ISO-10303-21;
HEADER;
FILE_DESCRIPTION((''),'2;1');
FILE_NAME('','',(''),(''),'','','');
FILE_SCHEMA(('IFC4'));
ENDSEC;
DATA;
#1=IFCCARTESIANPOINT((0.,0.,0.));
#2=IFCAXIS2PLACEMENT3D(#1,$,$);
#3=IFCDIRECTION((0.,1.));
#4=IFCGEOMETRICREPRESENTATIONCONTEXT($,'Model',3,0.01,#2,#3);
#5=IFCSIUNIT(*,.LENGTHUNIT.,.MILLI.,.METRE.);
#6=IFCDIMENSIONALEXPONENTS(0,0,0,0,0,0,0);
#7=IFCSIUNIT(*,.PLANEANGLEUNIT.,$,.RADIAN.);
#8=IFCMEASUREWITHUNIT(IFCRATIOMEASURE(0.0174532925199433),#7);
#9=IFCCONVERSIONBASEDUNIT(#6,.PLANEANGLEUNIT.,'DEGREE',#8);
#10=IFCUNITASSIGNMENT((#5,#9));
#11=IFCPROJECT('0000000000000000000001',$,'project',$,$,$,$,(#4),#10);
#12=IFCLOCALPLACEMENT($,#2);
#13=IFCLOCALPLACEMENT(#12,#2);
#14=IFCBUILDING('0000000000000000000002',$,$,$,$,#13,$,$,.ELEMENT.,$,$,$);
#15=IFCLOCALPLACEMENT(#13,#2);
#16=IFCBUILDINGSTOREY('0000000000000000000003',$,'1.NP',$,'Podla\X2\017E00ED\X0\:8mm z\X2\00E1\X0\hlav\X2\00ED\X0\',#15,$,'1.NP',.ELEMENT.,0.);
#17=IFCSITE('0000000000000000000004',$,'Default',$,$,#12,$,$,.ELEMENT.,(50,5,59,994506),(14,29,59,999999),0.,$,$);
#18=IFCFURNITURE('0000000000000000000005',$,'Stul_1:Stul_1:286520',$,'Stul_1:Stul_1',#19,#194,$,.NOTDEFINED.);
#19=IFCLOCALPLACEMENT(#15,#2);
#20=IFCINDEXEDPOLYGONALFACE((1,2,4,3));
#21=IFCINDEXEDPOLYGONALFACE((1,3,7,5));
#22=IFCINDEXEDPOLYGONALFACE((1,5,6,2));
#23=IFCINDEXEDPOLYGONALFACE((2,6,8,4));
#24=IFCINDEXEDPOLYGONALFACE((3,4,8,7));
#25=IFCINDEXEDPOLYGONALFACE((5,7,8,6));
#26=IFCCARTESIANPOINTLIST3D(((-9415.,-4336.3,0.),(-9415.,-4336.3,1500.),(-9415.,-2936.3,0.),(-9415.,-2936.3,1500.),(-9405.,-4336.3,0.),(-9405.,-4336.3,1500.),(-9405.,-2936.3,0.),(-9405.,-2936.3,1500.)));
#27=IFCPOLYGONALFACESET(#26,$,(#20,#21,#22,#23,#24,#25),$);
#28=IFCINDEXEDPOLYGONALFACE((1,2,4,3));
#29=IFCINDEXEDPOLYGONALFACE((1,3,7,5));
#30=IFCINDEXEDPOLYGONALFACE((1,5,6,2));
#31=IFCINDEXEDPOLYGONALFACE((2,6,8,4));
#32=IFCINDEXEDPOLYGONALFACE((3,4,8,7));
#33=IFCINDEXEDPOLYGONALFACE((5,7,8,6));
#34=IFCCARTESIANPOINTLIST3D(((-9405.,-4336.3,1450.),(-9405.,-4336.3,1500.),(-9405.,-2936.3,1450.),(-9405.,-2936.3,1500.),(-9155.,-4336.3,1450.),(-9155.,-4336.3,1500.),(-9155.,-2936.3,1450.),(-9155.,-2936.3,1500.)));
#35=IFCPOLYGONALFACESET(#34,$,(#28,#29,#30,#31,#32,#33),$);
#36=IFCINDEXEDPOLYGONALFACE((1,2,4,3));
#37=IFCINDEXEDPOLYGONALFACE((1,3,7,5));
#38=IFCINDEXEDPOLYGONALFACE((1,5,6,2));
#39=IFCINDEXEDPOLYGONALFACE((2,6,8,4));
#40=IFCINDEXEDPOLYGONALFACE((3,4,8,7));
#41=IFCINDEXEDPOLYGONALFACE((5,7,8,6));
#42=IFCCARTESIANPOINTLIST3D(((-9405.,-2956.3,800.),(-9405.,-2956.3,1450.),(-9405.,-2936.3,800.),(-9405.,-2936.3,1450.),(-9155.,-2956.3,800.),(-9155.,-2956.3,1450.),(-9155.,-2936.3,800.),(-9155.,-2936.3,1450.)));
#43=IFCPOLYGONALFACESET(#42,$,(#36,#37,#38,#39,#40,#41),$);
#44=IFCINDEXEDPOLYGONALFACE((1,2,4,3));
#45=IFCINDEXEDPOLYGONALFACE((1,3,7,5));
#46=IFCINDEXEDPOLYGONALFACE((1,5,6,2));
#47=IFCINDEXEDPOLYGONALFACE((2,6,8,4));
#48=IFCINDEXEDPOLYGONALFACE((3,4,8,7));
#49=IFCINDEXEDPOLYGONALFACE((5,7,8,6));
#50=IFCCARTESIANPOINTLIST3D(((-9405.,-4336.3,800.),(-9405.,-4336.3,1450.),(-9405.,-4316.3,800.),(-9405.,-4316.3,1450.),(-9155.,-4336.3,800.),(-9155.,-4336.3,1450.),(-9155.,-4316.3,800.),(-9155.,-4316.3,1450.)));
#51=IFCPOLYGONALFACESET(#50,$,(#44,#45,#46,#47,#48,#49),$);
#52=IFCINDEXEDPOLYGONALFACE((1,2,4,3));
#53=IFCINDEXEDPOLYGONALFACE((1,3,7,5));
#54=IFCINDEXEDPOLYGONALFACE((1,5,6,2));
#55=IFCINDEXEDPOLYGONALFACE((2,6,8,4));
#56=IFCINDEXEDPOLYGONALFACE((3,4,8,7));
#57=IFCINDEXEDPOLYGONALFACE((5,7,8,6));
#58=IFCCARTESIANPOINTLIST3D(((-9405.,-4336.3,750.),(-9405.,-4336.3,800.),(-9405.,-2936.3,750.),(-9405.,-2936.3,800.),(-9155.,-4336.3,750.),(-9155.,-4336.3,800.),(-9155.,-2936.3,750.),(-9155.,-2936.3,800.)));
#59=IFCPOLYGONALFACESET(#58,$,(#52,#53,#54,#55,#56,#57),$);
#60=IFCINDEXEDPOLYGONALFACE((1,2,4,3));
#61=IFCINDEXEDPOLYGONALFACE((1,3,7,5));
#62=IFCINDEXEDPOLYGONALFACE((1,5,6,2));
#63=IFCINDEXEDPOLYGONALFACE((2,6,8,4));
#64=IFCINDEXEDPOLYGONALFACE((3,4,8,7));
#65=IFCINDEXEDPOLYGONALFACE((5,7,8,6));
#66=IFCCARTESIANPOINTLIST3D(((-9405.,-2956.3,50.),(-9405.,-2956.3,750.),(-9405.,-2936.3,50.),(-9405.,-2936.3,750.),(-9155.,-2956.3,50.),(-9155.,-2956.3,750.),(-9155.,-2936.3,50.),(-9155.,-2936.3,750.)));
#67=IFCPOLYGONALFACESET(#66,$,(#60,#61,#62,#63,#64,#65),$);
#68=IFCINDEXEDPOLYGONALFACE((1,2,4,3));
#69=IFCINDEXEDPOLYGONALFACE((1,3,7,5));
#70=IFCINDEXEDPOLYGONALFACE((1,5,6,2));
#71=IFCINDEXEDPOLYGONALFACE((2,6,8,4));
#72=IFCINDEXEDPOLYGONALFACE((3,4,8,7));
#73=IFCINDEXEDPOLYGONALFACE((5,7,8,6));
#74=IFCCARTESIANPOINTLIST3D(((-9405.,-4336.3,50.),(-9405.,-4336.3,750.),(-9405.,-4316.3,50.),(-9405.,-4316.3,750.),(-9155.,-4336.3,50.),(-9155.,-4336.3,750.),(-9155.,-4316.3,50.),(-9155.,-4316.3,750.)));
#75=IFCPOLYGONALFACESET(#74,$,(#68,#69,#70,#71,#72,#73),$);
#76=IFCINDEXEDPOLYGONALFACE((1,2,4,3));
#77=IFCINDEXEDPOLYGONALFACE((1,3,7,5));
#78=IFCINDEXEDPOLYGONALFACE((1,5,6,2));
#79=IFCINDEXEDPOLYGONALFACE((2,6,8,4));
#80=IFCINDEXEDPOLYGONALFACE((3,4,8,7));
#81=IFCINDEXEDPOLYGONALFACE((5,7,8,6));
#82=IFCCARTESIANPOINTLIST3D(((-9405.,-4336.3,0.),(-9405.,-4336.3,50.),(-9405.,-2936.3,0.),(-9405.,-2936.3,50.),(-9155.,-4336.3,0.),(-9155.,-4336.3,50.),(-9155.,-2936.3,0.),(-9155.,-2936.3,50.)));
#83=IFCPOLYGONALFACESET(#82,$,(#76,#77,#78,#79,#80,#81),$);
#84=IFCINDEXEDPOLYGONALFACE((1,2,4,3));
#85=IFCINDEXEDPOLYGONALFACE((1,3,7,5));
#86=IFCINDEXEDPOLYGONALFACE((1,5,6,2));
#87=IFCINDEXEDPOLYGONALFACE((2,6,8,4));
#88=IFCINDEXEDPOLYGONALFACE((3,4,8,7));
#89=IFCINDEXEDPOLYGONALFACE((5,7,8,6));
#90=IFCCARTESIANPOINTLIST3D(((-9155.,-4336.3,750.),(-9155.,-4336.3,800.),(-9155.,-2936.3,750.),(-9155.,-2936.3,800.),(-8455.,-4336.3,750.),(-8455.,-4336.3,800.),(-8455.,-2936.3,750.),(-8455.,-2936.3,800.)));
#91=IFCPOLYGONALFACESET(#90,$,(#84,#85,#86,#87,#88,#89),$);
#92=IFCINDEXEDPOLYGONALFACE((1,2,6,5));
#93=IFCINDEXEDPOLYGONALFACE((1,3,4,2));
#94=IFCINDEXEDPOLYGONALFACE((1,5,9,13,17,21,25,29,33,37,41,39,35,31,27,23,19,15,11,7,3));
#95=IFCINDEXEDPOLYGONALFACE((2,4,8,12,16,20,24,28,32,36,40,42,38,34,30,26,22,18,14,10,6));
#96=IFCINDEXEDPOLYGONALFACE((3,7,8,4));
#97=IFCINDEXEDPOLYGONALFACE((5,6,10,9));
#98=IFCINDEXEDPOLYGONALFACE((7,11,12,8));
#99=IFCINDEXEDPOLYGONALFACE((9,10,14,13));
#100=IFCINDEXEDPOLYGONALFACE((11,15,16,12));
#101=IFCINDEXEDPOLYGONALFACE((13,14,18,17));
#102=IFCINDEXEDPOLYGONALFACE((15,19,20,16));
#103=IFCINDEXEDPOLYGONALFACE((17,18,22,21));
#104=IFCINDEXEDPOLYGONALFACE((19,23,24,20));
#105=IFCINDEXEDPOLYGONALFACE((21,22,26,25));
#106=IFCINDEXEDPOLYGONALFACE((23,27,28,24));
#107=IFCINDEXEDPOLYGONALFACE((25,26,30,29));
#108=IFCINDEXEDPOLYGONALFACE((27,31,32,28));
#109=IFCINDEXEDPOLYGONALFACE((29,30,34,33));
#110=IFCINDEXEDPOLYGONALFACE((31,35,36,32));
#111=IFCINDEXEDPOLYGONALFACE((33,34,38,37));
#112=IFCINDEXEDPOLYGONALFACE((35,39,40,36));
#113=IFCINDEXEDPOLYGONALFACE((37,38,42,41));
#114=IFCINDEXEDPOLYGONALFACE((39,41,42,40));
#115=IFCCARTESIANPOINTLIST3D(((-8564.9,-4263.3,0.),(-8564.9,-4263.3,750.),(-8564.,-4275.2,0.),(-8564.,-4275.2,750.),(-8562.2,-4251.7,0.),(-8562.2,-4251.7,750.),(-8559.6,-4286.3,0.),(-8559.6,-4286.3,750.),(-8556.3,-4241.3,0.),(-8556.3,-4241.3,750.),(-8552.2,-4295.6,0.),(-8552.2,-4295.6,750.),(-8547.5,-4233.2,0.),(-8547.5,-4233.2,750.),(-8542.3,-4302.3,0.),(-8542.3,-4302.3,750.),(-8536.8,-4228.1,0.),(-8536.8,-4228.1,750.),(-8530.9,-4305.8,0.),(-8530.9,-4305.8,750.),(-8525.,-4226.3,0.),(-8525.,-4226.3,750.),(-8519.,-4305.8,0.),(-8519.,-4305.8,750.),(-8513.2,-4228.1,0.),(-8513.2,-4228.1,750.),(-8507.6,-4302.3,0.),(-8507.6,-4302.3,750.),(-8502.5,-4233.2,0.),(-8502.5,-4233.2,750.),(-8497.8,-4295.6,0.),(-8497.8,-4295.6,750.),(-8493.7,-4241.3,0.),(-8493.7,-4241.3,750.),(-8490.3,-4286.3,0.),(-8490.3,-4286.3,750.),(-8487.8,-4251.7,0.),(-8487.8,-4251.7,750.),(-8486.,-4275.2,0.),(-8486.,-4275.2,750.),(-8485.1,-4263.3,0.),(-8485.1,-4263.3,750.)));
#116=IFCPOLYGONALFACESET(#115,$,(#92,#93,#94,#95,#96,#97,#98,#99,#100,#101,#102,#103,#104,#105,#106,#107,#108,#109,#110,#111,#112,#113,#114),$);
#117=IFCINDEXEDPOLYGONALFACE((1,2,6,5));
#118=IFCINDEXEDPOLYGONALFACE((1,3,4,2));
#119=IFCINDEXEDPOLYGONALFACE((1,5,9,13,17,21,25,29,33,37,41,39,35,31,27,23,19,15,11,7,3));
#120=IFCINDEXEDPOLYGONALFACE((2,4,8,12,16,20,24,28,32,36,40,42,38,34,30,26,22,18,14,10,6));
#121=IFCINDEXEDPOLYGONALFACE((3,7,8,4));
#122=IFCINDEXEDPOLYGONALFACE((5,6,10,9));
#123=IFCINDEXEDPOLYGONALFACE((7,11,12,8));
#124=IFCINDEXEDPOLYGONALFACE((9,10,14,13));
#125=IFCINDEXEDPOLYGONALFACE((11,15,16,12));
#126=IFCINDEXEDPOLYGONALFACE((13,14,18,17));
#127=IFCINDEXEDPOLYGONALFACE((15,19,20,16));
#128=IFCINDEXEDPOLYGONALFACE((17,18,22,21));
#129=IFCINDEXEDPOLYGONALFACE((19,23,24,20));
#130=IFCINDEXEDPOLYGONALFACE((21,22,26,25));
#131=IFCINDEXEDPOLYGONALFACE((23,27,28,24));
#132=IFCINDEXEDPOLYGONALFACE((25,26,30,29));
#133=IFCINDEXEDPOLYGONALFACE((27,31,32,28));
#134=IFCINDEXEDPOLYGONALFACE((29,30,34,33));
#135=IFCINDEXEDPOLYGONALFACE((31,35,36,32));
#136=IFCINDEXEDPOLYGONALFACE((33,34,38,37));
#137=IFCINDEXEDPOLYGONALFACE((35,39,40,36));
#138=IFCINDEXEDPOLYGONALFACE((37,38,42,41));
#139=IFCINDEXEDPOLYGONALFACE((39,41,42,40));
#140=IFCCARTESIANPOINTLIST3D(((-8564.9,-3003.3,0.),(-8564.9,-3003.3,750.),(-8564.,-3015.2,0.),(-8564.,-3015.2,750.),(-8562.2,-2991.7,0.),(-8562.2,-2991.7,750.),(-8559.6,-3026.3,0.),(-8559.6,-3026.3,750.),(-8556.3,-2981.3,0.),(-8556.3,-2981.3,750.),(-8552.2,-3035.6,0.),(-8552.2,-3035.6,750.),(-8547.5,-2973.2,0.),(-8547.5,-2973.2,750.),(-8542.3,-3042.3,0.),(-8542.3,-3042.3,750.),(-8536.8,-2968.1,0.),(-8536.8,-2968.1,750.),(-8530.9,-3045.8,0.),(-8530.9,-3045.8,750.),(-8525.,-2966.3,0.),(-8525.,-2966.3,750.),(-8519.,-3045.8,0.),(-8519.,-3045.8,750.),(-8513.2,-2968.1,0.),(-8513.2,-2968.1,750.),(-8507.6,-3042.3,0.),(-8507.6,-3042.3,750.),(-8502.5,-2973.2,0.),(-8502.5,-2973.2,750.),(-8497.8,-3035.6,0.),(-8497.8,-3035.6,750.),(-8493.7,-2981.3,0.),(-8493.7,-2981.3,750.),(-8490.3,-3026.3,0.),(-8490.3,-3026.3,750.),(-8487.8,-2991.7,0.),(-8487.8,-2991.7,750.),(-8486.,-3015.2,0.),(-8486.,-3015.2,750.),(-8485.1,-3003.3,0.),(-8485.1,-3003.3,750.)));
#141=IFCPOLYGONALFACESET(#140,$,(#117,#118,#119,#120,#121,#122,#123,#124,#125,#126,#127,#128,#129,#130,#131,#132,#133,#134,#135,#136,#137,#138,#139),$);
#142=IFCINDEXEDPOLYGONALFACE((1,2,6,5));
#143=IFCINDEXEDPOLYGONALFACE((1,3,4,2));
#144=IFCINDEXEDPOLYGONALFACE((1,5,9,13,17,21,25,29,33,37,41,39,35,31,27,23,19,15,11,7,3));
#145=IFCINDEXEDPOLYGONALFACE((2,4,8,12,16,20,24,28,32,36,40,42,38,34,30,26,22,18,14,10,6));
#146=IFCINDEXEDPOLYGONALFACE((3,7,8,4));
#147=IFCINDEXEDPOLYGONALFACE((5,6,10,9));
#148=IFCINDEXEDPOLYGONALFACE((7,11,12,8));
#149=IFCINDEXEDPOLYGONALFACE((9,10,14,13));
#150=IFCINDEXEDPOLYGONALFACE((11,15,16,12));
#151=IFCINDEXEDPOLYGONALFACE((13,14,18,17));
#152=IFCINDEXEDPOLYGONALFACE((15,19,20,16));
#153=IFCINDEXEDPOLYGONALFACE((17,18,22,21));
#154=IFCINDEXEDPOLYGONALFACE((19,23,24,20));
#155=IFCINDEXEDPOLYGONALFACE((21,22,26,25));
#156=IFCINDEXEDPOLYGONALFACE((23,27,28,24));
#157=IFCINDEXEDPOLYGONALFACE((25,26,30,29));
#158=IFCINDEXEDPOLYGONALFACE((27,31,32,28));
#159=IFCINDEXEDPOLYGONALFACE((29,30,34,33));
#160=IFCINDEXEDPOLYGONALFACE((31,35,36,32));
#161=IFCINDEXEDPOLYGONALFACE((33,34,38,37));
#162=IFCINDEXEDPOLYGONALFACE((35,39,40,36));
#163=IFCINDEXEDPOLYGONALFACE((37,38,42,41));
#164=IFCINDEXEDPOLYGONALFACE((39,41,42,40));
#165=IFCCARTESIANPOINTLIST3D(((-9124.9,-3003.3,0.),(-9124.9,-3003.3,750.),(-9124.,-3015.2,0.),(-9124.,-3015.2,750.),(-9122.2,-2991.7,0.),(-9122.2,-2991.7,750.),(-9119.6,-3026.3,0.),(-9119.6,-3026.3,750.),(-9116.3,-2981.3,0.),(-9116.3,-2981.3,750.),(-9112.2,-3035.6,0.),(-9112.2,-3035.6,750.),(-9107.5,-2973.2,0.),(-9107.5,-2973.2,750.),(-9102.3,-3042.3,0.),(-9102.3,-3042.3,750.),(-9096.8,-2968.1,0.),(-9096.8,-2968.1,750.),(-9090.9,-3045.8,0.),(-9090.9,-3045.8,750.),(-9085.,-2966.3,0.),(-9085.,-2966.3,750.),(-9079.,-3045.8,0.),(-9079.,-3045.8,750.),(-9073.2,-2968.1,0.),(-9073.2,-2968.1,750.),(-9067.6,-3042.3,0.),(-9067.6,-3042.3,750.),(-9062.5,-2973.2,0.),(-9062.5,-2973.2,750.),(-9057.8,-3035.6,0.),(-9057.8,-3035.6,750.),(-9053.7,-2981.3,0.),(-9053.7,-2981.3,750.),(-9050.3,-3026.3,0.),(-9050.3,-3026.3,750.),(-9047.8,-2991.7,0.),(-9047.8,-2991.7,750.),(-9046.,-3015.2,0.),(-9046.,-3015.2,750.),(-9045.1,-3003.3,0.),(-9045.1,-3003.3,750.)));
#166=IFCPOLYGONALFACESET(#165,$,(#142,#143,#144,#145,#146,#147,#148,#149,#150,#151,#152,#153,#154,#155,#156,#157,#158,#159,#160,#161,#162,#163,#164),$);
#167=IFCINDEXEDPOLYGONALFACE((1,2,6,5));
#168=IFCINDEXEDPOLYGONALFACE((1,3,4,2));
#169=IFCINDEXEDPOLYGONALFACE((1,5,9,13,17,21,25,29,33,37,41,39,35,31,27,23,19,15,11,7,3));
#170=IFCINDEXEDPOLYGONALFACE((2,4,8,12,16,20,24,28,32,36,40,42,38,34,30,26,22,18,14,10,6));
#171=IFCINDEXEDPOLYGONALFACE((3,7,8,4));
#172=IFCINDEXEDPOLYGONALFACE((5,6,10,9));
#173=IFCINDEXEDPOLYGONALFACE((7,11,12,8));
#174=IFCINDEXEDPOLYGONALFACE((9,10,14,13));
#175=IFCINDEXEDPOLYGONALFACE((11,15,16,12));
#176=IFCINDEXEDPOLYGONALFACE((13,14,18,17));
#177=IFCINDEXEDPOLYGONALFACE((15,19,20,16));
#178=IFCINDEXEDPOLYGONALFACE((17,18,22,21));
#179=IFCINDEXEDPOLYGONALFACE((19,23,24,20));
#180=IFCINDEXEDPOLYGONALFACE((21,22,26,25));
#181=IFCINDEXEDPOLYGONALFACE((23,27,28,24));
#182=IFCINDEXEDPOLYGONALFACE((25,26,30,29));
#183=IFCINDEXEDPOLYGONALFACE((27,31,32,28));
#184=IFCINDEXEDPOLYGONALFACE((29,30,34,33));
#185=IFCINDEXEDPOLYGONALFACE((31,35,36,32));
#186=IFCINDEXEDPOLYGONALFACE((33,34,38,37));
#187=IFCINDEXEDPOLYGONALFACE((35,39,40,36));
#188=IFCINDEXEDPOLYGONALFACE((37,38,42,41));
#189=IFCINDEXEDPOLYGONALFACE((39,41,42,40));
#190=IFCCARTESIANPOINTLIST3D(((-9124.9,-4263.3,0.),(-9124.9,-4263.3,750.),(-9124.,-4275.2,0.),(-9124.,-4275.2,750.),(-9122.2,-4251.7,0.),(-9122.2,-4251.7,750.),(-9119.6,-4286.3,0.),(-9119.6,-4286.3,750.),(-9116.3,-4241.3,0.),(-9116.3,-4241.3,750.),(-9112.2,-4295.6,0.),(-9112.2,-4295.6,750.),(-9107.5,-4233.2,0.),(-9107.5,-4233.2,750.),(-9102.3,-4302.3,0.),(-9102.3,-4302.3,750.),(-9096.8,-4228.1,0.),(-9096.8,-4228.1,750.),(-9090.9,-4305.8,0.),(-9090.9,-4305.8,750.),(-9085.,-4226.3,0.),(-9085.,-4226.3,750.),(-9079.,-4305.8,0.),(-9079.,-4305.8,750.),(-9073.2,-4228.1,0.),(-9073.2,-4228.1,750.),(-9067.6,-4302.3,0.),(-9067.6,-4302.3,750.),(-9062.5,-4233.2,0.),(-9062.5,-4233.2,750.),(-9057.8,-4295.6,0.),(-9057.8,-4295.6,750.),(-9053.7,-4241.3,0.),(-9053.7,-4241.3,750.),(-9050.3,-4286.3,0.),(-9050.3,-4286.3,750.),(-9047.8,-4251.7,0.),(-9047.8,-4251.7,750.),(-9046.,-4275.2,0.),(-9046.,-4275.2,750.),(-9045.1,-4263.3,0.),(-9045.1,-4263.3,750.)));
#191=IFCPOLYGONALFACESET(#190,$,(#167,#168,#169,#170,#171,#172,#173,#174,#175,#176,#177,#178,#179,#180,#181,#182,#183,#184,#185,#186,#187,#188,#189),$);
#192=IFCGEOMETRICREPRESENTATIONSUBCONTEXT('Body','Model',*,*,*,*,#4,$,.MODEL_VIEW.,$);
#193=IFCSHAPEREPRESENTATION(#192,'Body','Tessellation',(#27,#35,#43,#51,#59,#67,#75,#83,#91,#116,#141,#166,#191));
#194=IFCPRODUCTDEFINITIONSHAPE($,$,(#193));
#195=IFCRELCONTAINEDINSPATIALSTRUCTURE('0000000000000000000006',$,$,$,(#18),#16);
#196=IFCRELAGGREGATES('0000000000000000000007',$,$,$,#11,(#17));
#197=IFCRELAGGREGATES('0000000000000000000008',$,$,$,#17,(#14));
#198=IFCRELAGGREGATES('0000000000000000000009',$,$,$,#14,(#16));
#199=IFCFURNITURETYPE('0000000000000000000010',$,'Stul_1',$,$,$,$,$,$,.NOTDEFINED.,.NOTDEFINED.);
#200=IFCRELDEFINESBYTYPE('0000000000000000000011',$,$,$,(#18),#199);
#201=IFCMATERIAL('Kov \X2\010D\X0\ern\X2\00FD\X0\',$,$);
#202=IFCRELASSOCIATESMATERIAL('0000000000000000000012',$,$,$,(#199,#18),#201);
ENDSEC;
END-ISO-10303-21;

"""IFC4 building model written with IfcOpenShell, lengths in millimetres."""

from ifc_helpers import new_model, entity, si_unit, converted_unit, direction, frame, frame_2d, origin, origin_2d_with_axis, place, context, subcontext, project, spatial, rectangle, circle, extrude, source, transform, mapped, material, type_object, type_shapes, element, save


model = new_model("IFC4")

# Units and contexts
model_context = context("Model", 3, precision=0.01, world=origin(), true_north=direction((0.0, 1.0)))
body_context = subcontext(model_context, "Body", "Model", "MODEL_VIEW")
ifc_project = project(units=[si_unit("LENGTHUNIT", "METRE", prefix="MILLI"), converted_unit("PLANEANGLEUNIT", "DEGREE", entity("IfcRatioMeasure", 0.0174532925199433), si_unit("PLANEANGLEUNIT", "RADIAN"), dimensions=[0, 0, 0, 0, 0, 0, 0])], contexts=[model_context])

# Site, building, storey
site_placement = place(None, origin())
site = spatial("IfcSite", under=ifc_project, at=site_placement, Name="Default", CompositionType="ELEMENT", RefLatitude=(50, 5, 59, 994506), RefLongitude=(14, 29, 59, 999999), RefElevation=0.0)
building_placement = place(site_placement, origin())
building = spatial("IfcBuilding", under=site, at=building_placement, CompositionType="ELEMENT")
storey_placement = place(building_placement, origin())
storey = spatial("IfcBuildingStorey", under=building, at=storey_placement, Name="1.NP", ObjectType="Podlaží:8mm záhlaví", LongName="1.NP", CompositionType="ELEMENT", Elevation=0.0)

# Furniture
ifc_material_1 = material(Name="Kov černý")
furniture_type = type_object("IfcFurnitureType", Name="Stul_1", AssemblyPlace="NOTDEFINED", PredefinedType="NOTDEFINED", material=ifc_material_1)
shared_shape_1 = source(origin(), body_context, "Body", "SweptSolid", [
    extrude(rectangle(XDim=1400.0, YDim=10.0, at=origin_2d_with_axis()), frame((0.0, 605.0, 0.0), z_axis=(0.0, 0.0, 1.0), x_axis=(-1.0, 0.0, 0.0)), (0.0, 0.0, 1.0), 1500.0),
    extrude(rectangle(XDim=1400.0, YDim=250.0, at=frame_2d((0.0, 0.0), x_axis=(1.0, 0.0))), frame((0.0, 475.0, 1450.0), z_axis=(0.0, 0.0, 1.0), x_axis=(-1.0, 0.0, 0.0)), (0.0, 0.0, 1.0), 50.0),
    extrude(rectangle(XDim=20.0, YDim=250.0, at=origin_2d_with_axis()), frame((690.0, 475.0, 800.0), z_axis=(0.0, 0.0, 1.0), x_axis=(-1.0, 0.0, 0.0)), (0.0, 0.0, 1.0), 650.0),
    extrude(rectangle(XDim=20.0, YDim=250.0, at=frame_2d((0.0, 0.0), x_axis=(1.0, 0.0))), frame((-690.0, 475.0, 800.0), z_axis=(0.0, 0.0, 1.0), x_axis=(-1.0, 0.0, 0.0)), (0.0, 0.0, 1.0), 650.0),
    extrude(rectangle(XDim=1400.0, YDim=250.0, at=origin_2d_with_axis()), frame((0.0, 475.0, 750.0), z_axis=(0.0, 0.0, 1.0), x_axis=(-1.0, 0.0, 0.0)), (0.0, 0.0, 1.0), 50.0),
    extrude(rectangle(XDim=20.0, YDim=250.0, at=origin_2d_with_axis()), frame((690.0, 475.0, 50.0), z_axis=(0.0, 0.0, 1.0), x_axis=(-1.0, 0.0, 0.0)), (0.0, 0.0, 1.0), 700.0),
    extrude(rectangle(XDim=20.0, YDim=250.0, at=frame_2d((0.0, 0.0), x_axis=(1.0, 0.0))), frame((-690.0, 475.0, 50.0), z_axis=(0.0, 0.0, 1.0), x_axis=(-1.0, 0.0, 0.0)), (0.0, 0.0, 1.0), 700.0),
    extrude(rectangle(XDim=1400.0, YDim=250.0, at=origin_2d_with_axis()), frame((0.0, 475.0, 0.0), z_axis=(0.0, 0.0, 1.0), x_axis=(-1.0, 0.0, 0.0)), (0.0, 0.0, 1.0), 50.0),
    extrude(rectangle(XDim=1400.0, YDim=700.0, at=origin_2d_with_axis()), frame((0.0, 0.0, 750.0), z_axis=(0.0, 0.0, 1.0), x_axis=(-1.0, 0.0, 0.0)), (0.0, 0.0, 1.0), 50.0),
    extrude(circle(Radius=40.0, at=frame_2d((0.0, 0.0), x_axis=(1.0, 0.0))), frame((-630.0, -280.0, 0.0)), (0.0, 0.0, 1.0), 750.0),
    extrude(circle(Radius=40.0, at=frame_2d((0.0, 0.0), x_axis=(1.0, 0.0))), frame((630.0, -280.0, 0.0)), (0.0, 0.0, 1.0), 750.0),
    extrude(circle(Radius=40.0, at=frame_2d((0.0, 0.0), x_axis=(1.0, 0.0))), frame((630.0, 280.0, 0.0)), (0.0, 0.0, 1.0), 750.0),
    extrude(circle(Radius=40.0, at=frame_2d((0.0, 0.0), x_axis=(1.0, 0.0))), frame((-630.0, 280.0, 0.0)), (0.0, 0.0, 1.0), 750.0),
])
type_shapes(furniture_type, [shared_shape_1])
for number, where, z_axis, x_axis, name in (
    (1, (-8805.0, -3636.3, 0.0), (0.0, 0.0, 1.0), (0.0, 1.0, 0.0), "Stul_1:Stul_1:286520"),
):
    element("IfcFurniture", number, at=place(storey_placement, frame(where, z_axis=z_axis, x_axis=x_axis)), inside=storey, type_object=furniture_type, material=ifc_material_1, Name=name, ObjectType="Stul_1:Stul_1", PredefinedType="NOTDEFINED", context=body_context, shape_type="MappedRepresentation", body=[
        mapped(shared_shape_1, transform((0.0, 0.0, 0.0), scale=1.0)),
    ])

save(model, "model.ifc")
